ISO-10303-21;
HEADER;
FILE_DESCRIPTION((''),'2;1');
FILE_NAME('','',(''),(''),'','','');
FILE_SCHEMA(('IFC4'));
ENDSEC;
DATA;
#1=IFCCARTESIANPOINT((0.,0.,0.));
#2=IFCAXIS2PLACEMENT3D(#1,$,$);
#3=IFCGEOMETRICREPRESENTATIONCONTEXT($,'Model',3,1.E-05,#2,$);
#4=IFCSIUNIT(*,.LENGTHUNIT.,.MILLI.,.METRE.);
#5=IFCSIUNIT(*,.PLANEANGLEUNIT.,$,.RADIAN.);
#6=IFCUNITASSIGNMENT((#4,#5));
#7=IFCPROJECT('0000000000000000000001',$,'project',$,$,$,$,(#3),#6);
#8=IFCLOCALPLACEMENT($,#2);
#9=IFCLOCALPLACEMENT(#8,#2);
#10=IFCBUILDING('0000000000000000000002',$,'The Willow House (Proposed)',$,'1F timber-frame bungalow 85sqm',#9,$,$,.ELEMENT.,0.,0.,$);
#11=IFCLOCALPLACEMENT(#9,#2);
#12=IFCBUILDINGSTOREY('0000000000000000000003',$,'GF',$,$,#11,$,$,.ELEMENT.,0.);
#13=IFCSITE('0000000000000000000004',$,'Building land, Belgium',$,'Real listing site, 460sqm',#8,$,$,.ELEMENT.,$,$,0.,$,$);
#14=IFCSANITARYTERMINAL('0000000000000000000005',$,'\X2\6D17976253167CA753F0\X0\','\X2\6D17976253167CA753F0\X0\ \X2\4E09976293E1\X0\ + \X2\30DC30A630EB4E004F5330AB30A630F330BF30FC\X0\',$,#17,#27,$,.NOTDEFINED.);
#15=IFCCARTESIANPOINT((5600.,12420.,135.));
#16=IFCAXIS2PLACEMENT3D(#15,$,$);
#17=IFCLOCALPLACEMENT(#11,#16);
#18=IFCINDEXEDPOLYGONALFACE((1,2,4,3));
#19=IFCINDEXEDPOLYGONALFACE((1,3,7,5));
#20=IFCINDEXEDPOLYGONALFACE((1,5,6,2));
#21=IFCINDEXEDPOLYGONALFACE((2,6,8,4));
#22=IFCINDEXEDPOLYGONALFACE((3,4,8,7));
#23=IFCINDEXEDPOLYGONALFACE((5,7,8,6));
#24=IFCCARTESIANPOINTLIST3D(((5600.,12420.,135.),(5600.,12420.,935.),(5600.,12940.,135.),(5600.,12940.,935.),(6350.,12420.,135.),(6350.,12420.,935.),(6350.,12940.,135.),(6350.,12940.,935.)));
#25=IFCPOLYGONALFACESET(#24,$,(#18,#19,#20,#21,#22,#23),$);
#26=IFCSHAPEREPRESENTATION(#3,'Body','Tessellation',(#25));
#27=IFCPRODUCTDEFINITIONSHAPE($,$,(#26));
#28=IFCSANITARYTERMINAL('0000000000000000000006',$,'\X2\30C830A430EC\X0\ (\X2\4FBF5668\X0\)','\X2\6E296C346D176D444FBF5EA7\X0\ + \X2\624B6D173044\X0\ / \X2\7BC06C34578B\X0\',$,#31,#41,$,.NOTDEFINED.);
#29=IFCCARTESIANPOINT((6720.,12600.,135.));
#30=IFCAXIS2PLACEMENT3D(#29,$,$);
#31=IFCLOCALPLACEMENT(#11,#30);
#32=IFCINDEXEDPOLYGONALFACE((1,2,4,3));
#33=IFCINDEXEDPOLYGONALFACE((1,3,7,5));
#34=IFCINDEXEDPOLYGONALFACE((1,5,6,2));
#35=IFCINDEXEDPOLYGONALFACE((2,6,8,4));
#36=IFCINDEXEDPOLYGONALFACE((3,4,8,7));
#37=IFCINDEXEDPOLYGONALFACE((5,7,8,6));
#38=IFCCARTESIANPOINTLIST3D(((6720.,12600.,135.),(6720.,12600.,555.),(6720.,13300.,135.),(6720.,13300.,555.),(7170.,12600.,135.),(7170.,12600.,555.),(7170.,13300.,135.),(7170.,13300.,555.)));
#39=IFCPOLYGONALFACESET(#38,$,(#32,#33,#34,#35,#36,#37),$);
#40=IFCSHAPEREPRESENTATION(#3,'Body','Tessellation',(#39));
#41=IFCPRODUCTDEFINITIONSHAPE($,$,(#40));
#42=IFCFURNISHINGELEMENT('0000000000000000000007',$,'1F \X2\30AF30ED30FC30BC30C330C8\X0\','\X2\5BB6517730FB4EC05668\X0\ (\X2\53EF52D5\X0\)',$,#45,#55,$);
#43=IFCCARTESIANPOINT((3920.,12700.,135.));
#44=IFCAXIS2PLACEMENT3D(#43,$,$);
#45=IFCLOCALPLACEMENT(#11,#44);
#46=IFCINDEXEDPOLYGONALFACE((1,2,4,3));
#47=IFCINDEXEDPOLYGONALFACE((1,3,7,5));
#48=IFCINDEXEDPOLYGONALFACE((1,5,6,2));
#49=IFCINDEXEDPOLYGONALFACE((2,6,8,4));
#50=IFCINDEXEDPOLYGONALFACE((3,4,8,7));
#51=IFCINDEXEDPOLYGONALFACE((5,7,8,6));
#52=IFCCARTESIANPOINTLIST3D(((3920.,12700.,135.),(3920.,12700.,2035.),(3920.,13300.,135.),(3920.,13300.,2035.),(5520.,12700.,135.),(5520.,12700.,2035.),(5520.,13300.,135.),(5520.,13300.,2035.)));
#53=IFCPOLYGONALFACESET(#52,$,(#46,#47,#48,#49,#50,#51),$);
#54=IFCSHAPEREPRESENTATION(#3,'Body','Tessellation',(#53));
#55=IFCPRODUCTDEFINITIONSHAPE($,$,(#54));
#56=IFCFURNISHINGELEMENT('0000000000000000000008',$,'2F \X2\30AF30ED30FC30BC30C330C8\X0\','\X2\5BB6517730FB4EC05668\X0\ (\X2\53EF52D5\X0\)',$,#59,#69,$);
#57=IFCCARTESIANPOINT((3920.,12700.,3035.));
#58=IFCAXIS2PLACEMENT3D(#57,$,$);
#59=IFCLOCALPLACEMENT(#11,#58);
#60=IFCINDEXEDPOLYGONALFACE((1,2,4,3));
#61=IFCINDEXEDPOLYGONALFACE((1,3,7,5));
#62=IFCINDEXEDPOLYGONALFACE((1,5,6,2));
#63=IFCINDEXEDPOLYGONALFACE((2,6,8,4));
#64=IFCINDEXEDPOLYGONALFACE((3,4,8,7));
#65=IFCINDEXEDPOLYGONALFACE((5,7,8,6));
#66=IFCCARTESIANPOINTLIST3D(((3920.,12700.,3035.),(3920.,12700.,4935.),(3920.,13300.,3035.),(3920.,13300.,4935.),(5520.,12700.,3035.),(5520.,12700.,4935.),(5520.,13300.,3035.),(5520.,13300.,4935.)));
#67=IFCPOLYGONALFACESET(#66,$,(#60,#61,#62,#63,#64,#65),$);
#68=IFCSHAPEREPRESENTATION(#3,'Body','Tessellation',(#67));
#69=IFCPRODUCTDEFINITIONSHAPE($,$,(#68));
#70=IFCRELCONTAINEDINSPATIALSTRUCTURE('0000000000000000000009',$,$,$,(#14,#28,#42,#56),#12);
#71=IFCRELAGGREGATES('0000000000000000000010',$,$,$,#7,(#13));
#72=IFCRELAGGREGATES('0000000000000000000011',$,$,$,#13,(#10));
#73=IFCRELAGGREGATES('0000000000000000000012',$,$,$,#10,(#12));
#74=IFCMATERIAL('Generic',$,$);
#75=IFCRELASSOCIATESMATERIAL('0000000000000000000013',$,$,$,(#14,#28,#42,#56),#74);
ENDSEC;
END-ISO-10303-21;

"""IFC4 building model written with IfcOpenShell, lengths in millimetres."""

from ifc_helpers import new_model, si_unit, frame, frame_2d, origin, place, context, project, spatial, rectangle, extrude, material, element, save


model = new_model("IFC4")

# Units and contexts
model_context = context("Model", 3, precision=1e-05, world=origin())
ifc_project = project(units=[si_unit("LENGTHUNIT", "METRE", prefix="MILLI"), si_unit("PLANEANGLEUNIT", "RADIAN")], contexts=[model_context])

# Site, building, storey
site_placement = place(None, origin())
site = spatial("IfcSite", under=ifc_project, at=site_placement, Name="Building land, Belgium", ObjectType="Real listing site, 460sqm", CompositionType="ELEMENT", RefElevation=0.0)
building_placement = place(site_placement, origin())
building = spatial("IfcBuilding", under=site, at=building_placement, Name="The Willow House (Proposed)", ObjectType="1F timber-frame bungalow 85sqm", CompositionType="ELEMENT", ElevationOfRefHeight=0.0, ElevationOfTerrain=0.0)
storey_placement = place(building_placement, origin())
storey = spatial("IfcBuildingStorey", under=building, at=storey_placement, Name="GF", CompositionType="ELEMENT", Elevation=0.0)

# Shared definitions
ifc_material_1 = material(Name="Generic")

# Sanitary terminals
sanitary_terminal_1_placement = place(storey_placement, frame((5600.0, 12420.0, 135.0)))
element("IfcSanitaryTerminal", 1, at=sanitary_terminal_1_placement, inside=storey, material=ifc_material_1, Name="洗面化粧台", Description="洗面化粧台 三面鏡 + ボウル一体カウンター", PredefinedType="NOTDEFINED", context=model_context, shape_type="SweptSolid", body=[
    extrude(rectangle(XDim=750.0, YDim=520.0, at=frame_2d((375.0, 260.0))), frame((5600.0, 12420.0, 135.0)), (0.0, 0.0, 1.0), 800.0),
])
sanitary_terminal_2_placement = place(storey_placement, frame((6720.0, 12600.0, 135.0)))
element("IfcSanitaryTerminal", 2, at=sanitary_terminal_2_placement, inside=storey, material=ifc_material_1, Name="トイレ (便器)", Description="温水洗浄便座 + 手洗い / 節水型", PredefinedType="NOTDEFINED", context=model_context, shape_type="SweptSolid", body=[
    extrude(rectangle(XDim=450.0, YDim=700.0, at=frame_2d((225.0, 350.0))), frame((6720.0, 12600.0, 135.0)), (0.0, 0.0, 1.0), 420.0),
])

# Furnishing elements
furnishing_1_placement = place(storey_placement, frame((3920.0, 12700.0, 135.0)))
element("IfcFurnishingElement", 3, at=furnishing_1_placement, inside=storey, material=ifc_material_1, Name="1F クローゼット", Description="家具・什器 (可動)", context=model_context, shape_type="SweptSolid", body=[
    extrude(rectangle(XDim=1600.0, YDim=600.0, at=frame_2d((800.0, 300.0))), frame((3920.0, 12700.0, 135.0)), (0.0, 0.0, 1.0), 1900.0),
])
furnishing_2_placement = place(storey_placement, frame((3920.0, 12700.0, 3035.0)))
element("IfcFurnishingElement", 4, at=furnishing_2_placement, inside=storey, material=ifc_material_1, Name="2F クローゼット", Description="家具・什器 (可動)", context=model_context, shape_type="SweptSolid", body=[
    extrude(rectangle(XDim=1600.0, YDim=600.0, at=frame_2d((800.0, 300.0))), frame((3920.0, 12700.0, 3035.0)), (0.0, 0.0, 1.0), 1900.0),
])

save(model, "model.ifc")
